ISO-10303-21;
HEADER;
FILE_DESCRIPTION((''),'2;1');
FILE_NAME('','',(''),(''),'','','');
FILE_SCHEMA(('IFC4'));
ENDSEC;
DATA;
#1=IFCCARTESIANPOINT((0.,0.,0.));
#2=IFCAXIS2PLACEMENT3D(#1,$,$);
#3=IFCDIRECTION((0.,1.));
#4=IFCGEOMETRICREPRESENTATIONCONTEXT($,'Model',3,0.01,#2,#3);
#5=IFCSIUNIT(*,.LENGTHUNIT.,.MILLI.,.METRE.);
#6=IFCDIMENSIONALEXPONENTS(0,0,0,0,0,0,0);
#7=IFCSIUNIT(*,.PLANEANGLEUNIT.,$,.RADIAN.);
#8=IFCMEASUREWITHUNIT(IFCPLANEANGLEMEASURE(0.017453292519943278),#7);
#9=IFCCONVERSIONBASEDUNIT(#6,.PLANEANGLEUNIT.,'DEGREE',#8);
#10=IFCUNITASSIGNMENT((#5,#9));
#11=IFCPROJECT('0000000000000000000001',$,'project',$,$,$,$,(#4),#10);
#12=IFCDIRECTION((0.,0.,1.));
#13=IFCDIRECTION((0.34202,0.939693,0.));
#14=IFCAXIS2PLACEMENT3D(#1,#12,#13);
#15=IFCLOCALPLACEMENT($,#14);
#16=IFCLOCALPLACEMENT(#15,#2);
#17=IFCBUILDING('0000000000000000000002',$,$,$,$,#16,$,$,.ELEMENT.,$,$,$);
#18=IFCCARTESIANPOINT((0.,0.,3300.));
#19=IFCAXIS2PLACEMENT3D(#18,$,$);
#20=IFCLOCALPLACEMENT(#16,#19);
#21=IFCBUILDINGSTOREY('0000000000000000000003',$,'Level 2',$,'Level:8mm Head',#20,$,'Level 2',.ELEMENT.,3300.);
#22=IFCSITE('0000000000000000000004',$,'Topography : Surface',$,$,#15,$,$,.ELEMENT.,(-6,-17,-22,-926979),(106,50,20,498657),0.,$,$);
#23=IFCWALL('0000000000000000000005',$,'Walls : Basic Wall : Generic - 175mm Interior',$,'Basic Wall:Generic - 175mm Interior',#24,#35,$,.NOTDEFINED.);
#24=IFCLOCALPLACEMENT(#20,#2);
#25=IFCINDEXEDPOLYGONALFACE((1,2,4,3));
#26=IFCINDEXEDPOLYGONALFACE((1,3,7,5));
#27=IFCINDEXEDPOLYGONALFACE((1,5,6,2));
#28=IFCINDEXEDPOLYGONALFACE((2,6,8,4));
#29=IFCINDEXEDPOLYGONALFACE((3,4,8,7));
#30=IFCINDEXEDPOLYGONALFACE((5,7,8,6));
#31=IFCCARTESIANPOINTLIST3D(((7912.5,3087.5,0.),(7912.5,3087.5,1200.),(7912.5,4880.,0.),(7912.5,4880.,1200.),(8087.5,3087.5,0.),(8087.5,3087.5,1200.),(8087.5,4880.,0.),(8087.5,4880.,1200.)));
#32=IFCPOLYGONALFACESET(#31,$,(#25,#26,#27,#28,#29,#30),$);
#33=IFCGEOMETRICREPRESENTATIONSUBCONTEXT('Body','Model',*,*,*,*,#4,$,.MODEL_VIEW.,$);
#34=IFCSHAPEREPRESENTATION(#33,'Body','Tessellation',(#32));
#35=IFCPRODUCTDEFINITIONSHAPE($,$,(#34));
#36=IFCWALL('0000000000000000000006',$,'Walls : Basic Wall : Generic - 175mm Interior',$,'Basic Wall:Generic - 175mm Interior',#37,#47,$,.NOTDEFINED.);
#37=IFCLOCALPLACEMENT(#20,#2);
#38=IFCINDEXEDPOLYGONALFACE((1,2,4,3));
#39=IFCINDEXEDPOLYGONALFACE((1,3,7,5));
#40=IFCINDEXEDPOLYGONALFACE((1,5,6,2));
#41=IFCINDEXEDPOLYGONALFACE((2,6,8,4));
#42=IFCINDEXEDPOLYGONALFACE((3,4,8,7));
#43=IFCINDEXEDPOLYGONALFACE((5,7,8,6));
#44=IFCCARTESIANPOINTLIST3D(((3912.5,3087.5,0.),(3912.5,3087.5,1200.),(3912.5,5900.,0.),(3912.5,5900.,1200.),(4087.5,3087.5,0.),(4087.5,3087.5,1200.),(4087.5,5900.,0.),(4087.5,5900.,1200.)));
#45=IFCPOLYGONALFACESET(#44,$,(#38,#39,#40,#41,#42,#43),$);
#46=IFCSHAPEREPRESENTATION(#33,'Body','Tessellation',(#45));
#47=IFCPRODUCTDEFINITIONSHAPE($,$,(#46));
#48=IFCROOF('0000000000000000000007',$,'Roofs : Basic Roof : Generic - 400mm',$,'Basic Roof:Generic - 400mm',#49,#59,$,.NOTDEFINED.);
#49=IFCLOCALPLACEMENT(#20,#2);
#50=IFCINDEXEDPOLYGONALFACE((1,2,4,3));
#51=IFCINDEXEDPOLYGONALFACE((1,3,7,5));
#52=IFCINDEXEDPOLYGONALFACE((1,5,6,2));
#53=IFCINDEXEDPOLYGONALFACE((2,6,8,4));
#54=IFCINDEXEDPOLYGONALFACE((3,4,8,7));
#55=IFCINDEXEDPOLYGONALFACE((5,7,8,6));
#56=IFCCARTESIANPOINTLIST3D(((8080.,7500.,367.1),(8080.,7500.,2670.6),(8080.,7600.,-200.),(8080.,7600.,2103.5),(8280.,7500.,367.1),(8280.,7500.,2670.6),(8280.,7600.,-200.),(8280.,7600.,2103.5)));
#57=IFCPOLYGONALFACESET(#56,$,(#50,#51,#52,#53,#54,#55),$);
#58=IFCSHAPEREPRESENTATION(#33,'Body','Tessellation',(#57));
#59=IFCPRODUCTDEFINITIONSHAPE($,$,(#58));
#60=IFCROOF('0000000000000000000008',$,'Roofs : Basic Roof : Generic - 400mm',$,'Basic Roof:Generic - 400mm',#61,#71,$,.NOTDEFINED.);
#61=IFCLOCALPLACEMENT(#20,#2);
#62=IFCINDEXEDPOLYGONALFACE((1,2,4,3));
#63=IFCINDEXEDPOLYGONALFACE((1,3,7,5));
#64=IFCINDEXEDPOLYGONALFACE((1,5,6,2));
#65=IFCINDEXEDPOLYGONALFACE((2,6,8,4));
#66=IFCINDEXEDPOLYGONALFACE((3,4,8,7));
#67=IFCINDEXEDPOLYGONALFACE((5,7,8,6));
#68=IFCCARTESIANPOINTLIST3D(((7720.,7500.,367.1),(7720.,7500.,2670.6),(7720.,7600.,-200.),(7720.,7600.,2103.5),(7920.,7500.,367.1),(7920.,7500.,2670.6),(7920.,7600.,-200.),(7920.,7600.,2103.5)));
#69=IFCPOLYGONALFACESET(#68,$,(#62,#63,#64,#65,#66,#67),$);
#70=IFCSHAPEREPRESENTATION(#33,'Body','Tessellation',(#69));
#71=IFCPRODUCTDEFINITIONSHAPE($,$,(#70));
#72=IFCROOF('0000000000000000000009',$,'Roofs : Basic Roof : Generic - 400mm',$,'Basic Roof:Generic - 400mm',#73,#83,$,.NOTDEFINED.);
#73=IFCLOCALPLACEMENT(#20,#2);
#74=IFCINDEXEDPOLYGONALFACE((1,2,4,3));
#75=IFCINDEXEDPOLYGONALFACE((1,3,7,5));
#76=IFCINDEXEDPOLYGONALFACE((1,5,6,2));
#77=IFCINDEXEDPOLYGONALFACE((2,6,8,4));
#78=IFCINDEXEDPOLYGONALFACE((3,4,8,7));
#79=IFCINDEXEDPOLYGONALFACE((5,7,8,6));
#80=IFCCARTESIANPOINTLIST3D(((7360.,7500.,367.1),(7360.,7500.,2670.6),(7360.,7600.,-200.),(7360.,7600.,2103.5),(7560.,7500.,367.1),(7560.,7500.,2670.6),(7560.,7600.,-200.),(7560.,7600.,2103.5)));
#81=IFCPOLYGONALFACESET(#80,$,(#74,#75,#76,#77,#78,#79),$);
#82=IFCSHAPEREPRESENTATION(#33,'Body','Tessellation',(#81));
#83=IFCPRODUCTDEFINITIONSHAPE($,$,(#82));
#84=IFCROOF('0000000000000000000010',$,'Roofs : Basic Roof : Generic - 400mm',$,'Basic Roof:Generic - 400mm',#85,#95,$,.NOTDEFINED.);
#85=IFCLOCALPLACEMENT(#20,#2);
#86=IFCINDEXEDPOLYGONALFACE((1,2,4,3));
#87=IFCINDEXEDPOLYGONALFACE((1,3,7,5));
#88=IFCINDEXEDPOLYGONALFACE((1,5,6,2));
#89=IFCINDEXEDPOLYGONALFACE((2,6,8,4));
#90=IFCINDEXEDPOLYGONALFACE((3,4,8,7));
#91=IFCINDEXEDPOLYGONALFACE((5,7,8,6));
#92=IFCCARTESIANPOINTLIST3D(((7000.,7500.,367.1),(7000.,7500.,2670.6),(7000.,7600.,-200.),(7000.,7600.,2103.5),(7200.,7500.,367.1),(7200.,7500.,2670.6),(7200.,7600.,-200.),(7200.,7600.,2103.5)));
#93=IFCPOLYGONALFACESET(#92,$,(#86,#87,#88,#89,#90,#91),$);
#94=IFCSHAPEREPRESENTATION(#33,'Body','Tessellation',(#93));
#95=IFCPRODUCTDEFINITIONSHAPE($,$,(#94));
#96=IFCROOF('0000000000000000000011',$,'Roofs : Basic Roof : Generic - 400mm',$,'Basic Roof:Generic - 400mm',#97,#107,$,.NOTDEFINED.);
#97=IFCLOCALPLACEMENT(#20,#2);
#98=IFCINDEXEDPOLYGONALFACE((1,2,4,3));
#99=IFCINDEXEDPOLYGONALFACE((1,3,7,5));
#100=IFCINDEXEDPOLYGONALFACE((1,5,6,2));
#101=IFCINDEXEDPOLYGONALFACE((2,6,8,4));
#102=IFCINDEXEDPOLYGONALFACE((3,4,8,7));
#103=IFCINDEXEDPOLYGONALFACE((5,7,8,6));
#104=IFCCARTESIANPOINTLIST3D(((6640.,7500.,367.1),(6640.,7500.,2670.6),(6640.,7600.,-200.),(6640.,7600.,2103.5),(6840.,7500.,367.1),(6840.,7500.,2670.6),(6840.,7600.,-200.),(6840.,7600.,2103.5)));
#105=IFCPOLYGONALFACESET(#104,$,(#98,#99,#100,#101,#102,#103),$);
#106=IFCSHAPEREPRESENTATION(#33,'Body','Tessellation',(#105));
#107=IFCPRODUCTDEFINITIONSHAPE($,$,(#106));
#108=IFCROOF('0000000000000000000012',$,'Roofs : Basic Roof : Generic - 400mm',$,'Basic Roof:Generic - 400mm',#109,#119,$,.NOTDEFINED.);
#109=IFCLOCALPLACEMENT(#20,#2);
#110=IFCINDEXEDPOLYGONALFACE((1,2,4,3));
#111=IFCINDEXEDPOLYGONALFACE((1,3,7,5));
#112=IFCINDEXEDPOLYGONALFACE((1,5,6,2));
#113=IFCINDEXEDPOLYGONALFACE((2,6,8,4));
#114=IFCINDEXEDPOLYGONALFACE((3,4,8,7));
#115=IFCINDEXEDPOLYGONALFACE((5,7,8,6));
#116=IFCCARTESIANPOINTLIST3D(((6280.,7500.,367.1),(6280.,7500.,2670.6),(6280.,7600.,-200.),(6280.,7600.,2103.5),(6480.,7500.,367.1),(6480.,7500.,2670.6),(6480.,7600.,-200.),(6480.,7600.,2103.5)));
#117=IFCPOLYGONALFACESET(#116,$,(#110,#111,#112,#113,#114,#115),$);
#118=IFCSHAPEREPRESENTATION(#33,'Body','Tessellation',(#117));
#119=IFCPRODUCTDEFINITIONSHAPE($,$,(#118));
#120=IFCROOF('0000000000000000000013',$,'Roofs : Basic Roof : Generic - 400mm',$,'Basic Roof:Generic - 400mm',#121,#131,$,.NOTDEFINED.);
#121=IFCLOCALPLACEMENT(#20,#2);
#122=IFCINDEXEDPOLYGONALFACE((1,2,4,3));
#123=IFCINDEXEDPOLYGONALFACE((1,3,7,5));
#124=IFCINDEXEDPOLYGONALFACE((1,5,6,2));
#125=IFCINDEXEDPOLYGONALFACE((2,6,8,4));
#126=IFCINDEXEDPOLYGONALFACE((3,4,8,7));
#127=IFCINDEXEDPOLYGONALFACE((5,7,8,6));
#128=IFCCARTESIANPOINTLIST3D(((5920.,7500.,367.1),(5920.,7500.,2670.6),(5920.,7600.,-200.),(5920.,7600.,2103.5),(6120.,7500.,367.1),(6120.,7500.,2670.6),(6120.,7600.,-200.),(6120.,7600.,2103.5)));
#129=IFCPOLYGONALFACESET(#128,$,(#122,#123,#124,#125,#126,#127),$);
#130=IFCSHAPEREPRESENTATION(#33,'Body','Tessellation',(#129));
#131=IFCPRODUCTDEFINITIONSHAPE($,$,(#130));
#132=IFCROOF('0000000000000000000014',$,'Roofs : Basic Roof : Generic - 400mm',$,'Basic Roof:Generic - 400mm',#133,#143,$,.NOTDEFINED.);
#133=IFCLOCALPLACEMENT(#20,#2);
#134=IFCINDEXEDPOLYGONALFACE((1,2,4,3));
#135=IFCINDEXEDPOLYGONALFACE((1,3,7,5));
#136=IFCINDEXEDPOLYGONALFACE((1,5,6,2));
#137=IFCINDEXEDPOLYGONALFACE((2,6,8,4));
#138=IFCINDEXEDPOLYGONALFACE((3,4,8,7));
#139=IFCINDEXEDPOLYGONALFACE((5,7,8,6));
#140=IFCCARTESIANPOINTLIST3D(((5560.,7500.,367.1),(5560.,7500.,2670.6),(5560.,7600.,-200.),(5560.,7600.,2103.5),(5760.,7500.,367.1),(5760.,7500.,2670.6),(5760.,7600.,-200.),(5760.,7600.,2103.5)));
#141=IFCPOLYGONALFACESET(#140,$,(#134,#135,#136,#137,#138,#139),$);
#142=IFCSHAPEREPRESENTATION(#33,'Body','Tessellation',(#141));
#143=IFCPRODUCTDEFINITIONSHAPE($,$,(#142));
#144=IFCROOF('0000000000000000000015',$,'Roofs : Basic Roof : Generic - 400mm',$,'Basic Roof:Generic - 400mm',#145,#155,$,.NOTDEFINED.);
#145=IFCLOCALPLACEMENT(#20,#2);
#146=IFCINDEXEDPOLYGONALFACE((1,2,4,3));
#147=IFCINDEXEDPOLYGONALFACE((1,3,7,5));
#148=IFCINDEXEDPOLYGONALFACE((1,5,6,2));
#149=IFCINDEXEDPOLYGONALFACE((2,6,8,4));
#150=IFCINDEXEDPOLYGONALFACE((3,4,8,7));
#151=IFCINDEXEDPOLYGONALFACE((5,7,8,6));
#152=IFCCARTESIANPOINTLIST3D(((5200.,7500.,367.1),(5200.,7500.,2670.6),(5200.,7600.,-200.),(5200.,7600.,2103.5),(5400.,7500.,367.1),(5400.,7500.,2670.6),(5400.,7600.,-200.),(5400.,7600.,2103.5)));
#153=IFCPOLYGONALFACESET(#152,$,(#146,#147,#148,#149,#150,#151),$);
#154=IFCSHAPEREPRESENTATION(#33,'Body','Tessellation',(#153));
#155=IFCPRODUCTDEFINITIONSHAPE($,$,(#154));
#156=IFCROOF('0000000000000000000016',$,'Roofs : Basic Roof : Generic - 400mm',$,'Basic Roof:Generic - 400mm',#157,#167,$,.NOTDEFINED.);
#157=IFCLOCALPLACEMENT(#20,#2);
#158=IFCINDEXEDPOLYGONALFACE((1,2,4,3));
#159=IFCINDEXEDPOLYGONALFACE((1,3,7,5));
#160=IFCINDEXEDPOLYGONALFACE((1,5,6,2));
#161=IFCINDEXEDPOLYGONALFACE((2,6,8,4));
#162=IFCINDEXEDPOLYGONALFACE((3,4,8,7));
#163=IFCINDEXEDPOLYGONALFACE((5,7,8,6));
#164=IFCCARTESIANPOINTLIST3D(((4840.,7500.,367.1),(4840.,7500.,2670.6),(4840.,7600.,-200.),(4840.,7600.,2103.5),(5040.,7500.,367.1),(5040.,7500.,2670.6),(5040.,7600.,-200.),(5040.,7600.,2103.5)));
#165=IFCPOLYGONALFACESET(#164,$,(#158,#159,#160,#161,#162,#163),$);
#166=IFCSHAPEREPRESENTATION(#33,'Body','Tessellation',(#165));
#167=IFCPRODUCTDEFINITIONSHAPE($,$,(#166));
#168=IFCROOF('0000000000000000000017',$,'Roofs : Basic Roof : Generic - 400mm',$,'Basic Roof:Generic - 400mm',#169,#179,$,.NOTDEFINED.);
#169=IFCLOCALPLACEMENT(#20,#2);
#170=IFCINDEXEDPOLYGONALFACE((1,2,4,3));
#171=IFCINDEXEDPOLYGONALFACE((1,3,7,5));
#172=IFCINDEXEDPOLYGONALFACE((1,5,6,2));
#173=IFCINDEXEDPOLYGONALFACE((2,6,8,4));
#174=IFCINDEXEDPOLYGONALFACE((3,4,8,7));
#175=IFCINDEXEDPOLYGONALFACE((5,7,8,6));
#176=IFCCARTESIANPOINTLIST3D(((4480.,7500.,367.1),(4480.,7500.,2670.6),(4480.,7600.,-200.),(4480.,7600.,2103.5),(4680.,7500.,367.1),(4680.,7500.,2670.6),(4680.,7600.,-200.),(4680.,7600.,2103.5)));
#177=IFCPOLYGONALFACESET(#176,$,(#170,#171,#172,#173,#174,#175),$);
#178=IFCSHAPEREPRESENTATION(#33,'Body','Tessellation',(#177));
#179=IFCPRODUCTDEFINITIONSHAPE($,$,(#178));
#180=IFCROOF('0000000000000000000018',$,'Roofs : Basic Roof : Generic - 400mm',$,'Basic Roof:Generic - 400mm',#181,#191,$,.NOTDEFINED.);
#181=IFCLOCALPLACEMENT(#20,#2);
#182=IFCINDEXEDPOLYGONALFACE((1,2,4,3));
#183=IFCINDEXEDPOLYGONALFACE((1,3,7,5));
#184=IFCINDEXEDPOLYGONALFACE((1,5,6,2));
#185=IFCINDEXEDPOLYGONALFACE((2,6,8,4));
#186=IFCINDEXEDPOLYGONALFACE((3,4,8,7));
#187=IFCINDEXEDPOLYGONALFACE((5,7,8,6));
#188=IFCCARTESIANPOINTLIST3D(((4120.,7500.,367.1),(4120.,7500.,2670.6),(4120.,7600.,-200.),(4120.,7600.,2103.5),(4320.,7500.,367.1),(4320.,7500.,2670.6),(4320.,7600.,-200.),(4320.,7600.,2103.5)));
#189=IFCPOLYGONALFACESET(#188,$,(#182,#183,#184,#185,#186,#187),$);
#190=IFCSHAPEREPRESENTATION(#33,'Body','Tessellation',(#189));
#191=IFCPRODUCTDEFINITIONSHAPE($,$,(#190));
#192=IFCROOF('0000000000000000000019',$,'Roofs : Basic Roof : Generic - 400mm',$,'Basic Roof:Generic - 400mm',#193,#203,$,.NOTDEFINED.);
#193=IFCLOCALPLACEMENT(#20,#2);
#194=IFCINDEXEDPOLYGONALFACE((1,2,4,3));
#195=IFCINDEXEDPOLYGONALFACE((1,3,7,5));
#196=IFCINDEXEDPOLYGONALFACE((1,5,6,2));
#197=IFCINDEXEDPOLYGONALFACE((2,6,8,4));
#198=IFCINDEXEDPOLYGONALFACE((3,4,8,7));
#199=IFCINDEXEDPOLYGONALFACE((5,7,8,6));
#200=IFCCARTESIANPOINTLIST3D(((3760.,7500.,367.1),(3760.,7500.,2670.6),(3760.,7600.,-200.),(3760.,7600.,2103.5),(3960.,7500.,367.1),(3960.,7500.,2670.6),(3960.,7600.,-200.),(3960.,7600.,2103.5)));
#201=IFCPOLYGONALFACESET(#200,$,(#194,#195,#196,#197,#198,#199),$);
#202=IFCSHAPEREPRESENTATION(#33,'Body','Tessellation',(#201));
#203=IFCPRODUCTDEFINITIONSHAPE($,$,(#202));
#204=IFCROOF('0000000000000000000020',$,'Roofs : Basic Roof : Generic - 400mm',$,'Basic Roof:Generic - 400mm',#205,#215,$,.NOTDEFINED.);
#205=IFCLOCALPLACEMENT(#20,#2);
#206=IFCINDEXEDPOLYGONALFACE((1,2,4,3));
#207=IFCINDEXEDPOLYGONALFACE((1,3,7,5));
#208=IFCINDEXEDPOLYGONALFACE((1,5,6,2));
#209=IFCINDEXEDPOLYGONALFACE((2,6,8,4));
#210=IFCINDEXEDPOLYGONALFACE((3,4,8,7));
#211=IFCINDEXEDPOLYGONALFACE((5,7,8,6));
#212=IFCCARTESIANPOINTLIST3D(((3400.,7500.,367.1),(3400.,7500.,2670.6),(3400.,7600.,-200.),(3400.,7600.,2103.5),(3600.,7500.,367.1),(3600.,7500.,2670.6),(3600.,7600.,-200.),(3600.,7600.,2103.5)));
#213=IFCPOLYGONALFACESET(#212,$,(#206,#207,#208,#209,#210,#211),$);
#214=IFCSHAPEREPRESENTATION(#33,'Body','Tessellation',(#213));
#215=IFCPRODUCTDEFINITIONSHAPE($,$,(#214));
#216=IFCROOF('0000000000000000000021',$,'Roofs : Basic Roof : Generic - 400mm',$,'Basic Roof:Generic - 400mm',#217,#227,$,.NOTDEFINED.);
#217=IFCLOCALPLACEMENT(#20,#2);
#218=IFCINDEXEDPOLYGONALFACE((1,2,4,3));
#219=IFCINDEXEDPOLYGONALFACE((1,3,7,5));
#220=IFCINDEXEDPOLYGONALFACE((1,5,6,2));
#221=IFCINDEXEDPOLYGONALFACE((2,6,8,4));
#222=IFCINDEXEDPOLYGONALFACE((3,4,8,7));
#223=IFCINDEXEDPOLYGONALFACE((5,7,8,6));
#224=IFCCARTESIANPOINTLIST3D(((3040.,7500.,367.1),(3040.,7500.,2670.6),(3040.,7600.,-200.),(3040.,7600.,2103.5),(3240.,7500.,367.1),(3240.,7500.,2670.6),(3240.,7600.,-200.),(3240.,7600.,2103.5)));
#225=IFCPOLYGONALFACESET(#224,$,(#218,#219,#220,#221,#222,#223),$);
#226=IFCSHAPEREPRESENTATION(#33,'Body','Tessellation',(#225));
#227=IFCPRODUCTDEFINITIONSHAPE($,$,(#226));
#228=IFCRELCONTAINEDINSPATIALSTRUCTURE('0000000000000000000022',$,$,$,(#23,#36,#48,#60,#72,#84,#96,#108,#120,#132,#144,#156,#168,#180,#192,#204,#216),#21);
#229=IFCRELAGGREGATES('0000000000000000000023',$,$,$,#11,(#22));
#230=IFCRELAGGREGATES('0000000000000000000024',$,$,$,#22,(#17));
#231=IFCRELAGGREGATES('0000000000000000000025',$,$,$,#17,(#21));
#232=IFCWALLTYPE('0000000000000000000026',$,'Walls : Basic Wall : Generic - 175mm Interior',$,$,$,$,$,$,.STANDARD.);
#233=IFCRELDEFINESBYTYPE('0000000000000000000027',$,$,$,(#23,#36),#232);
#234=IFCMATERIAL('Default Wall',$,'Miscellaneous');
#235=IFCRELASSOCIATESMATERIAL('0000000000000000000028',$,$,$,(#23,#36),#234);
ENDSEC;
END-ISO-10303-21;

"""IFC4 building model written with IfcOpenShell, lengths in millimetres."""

from ifc_helpers import new_model, entity, si_unit, converted_unit, direction, frame, origin, place, context, subcontext, project, spatial, indexed_curve, outline, extrude, material, type_object, element, save


model = new_model("IFC4")

# Units and contexts
model_context = context("Model", 3, precision=0.01, world=origin(), true_north=direction((0.0, 1.0)))
body_context = subcontext(model_context, "Body", "Model", "MODEL_VIEW")
ifc_project = project(units=[si_unit("LENGTHUNIT", "METRE", prefix="MILLI"), converted_unit("PLANEANGLEUNIT", "DEGREE", entity("IfcPlaneAngleMeasure", 0.017453292519943278), si_unit("PLANEANGLEUNIT", "RADIAN"), dimensions=[0, 0, 0, 0, 0, 0, 0])], contexts=[model_context])

# Site, building, storey
site_placement = place(None, frame((0.0, 0.0, 0.0), z_axis=(0.0, 0.0, 1.0), x_axis=(0.34202, 0.939693, 0.0)))
site = spatial("IfcSite", under=ifc_project, at=site_placement, Name="Topography : Surface", CompositionType="ELEMENT", RefLatitude=(-6, -17, -22, -926979), RefLongitude=(106, 50, 20, 498657), RefElevation=0.0)
building_placement = place(site_placement, origin())
building = spatial("IfcBuilding", under=site, at=building_placement, CompositionType="ELEMENT")
storey_placement = place(building_placement, frame((0.0, 0.0, 3300.0)))
storey = spatial("IfcBuildingStorey", under=building, at=storey_placement, Name="Level 2", ObjectType="Level:8mm Head", LongName="Level 2", CompositionType="ELEMENT", Elevation=3300.0)

# Walls
ifc_material = material(Name="Default Wall", Category="Miscellaneous")
wall_type = type_object("IfcWallType", Name="Walls : Basic Wall : Generic - 175mm Interior", PredefinedType="STANDARD")
wall_1_placement = place(storey_placement, frame((8000.0, 3087.5, 0.0), z_axis=(0.0, 0.0, 1.0), x_axis=(0.0, 1.0, 0.0)))
element("IfcWall", 1, at=wall_1_placement, inside=storey, type_object=wall_type, material=ifc_material, Name="Walls : Basic Wall : Generic - 175mm Interior", ObjectType="Basic Wall:Generic - 175mm Interior", PredefinedType="NOTDEFINED", context=body_context, shape_type="SweptSolid", body=[
    extrude(outline(indexed_curve([(1792.5, 87.5), (0.0, 87.5), (0.0, -87.5), (1792.5, -87.5), (1792.5, 87.5)], self_intersect=False)), origin(), (0.0, 0.0, 1.0), 1200.0),
])
wall_2_placement = place(storey_placement, frame((4000.0, 3087.5, 0.0), z_axis=(0.0, 0.0, 1.0), x_axis=(0.0, 1.0, 0.0)))
element("IfcWall", 2, at=wall_2_placement, inside=storey, type_object=wall_type, material=ifc_material, Name="Walls : Basic Wall : Generic - 175mm Interior", ObjectType="Basic Wall:Generic - 175mm Interior", PredefinedType="NOTDEFINED", context=body_context, shape_type="SweptSolid", body=[
    extrude(outline(indexed_curve([(2812.5, 87.5), (0.0, 87.5), (0.0, -87.5), (2812.5, -87.5), (2812.5, 87.5)], self_intersect=False)), origin(), (0.0, 0.0, 1.0), 1200.0),
])

# Roofs
for number, where, name in (
    (3, (8080.0, 7500.0, -200.0), "Roofs : Basic Roof : Generic - 400mm"),
    (4, (7720.0, 7500.0, -200.0), "Roofs : Basic Roof : Generic - 400mm"),
):
    element("IfcRoof", number, at=place(storey_placement, frame(where)), inside=storey, Name=name, ObjectType="Basic Roof:Generic - 400mm", PredefinedType="NOTDEFINED", context=body_context, shape_type="SweptSolid", body=[
        extrude(outline(indexed_curve([(100.0, 287.9), (-100.0, 287.9), (-100.0, -287.9), (100.0, -287.9), (100.0, 287.9)], self_intersect=False)), frame((100.0, 50.0, 283.6), z_axis=(0.0, 0.984808, 0.173648), x_axis=(1.0, 0.0, 0.0)), (0.0, -0.984808, 0.173648), 2303.5),
    ])
for number, where, name in (
    (5, (7360.0, 7500.0, -200.0), "Roofs : Basic Roof : Generic - 400mm"),
    (6, (7000.0, 7500.0, -200.0), "Roofs : Basic Roof : Generic - 400mm"),
):
    element("IfcRoof", number, at=place(storey_placement, frame(where)), inside=storey, Name=name, ObjectType="Basic Roof:Generic - 400mm", PredefinedType="NOTDEFINED", context=body_context, shape_type="SweptSolid", body=[
        extrude(outline(indexed_curve([(100.0, 287.9), (-100.0, 287.9), (-100.0, -287.9), (100.0, -287.9), (100.0, 287.9)], self_intersect=False)), frame((100.0, 50.0, 283.6), z_axis=(0.0, 0.984808, 0.173648), x_axis=(1.0, 0.0, 0.0)), (0.0, -0.984808, 0.173648), 2303.5),
    ])
for number, where, name in (
    (7, (6640.0, 7500.0, -200.0), "Roofs : Basic Roof : Generic - 400mm"),
    (8, (6280.0, 7500.0, -200.0), "Roofs : Basic Roof : Generic - 400mm"),
    (9, (5920.0, 7500.0, -200.0), "Roofs : Basic Roof : Generic - 400mm"),
    (10, (5560.0, 7500.0, -200.0), "Roofs : Basic Roof : Generic - 400mm"),
    (11, (5200.0, 7500.0, -200.0), "Roofs : Basic Roof : Generic - 400mm"),
    (12, (4840.0, 7500.0, -200.0), "Roofs : Basic Roof : Generic - 400mm"),
    (13, (4480.0, 7500.0, -200.0), "Roofs : Basic Roof : Generic - 400mm"),
    (14, (4120.0, 7500.0, -200.0), "Roofs : Basic Roof : Generic - 400mm"),
    (15, (3760.0, 7500.0, -200.0), "Roofs : Basic Roof : Generic - 400mm"),
    (16, (3400.0, 7500.0, -200.0), "Roofs : Basic Roof : Generic - 400mm"),
):
    element("IfcRoof", number, at=place(storey_placement, frame(where)), inside=storey, Name=name, ObjectType="Basic Roof:Generic - 400mm", PredefinedType="NOTDEFINED", context=body_context, shape_type="SweptSolid", body=[
        extrude(outline(indexed_curve([(100.0, 287.9), (-100.0, 287.9), (-100.0, -287.9), (100.0, -287.9), (100.0, 287.9)], self_intersect=False)), frame((100.0, 50.0, 283.6), z_axis=(0.0, 0.984808, 0.173648), x_axis=(1.0, 0.0, 0.0)), (0.0, -0.984808, 0.173648), 2303.5),
    ])
for number, where, name in (
    (17, (3040.0, 7500.0, -200.0), "Roofs : Basic Roof : Generic - 400mm"),
):
    element("IfcRoof", number, at=place(storey_placement, frame(where)), inside=storey, Name=name, ObjectType="Basic Roof:Generic - 400mm", PredefinedType="NOTDEFINED", context=body_context, shape_type="SweptSolid", body=[
        extrude(outline(indexed_curve([(100.0, 287.9), (-100.0, 287.9), (-100.0, -287.9), (100.0, -287.9), (100.0, 287.9)], self_intersect=False)), frame((100.0, 50.0, 283.6), z_axis=(0.0, 0.984808, 0.173648), x_axis=(1.0, 0.0, 0.0)), (0.0, -0.984808, 0.173648), 2303.5),
    ])

save(model, "model.ifc")
